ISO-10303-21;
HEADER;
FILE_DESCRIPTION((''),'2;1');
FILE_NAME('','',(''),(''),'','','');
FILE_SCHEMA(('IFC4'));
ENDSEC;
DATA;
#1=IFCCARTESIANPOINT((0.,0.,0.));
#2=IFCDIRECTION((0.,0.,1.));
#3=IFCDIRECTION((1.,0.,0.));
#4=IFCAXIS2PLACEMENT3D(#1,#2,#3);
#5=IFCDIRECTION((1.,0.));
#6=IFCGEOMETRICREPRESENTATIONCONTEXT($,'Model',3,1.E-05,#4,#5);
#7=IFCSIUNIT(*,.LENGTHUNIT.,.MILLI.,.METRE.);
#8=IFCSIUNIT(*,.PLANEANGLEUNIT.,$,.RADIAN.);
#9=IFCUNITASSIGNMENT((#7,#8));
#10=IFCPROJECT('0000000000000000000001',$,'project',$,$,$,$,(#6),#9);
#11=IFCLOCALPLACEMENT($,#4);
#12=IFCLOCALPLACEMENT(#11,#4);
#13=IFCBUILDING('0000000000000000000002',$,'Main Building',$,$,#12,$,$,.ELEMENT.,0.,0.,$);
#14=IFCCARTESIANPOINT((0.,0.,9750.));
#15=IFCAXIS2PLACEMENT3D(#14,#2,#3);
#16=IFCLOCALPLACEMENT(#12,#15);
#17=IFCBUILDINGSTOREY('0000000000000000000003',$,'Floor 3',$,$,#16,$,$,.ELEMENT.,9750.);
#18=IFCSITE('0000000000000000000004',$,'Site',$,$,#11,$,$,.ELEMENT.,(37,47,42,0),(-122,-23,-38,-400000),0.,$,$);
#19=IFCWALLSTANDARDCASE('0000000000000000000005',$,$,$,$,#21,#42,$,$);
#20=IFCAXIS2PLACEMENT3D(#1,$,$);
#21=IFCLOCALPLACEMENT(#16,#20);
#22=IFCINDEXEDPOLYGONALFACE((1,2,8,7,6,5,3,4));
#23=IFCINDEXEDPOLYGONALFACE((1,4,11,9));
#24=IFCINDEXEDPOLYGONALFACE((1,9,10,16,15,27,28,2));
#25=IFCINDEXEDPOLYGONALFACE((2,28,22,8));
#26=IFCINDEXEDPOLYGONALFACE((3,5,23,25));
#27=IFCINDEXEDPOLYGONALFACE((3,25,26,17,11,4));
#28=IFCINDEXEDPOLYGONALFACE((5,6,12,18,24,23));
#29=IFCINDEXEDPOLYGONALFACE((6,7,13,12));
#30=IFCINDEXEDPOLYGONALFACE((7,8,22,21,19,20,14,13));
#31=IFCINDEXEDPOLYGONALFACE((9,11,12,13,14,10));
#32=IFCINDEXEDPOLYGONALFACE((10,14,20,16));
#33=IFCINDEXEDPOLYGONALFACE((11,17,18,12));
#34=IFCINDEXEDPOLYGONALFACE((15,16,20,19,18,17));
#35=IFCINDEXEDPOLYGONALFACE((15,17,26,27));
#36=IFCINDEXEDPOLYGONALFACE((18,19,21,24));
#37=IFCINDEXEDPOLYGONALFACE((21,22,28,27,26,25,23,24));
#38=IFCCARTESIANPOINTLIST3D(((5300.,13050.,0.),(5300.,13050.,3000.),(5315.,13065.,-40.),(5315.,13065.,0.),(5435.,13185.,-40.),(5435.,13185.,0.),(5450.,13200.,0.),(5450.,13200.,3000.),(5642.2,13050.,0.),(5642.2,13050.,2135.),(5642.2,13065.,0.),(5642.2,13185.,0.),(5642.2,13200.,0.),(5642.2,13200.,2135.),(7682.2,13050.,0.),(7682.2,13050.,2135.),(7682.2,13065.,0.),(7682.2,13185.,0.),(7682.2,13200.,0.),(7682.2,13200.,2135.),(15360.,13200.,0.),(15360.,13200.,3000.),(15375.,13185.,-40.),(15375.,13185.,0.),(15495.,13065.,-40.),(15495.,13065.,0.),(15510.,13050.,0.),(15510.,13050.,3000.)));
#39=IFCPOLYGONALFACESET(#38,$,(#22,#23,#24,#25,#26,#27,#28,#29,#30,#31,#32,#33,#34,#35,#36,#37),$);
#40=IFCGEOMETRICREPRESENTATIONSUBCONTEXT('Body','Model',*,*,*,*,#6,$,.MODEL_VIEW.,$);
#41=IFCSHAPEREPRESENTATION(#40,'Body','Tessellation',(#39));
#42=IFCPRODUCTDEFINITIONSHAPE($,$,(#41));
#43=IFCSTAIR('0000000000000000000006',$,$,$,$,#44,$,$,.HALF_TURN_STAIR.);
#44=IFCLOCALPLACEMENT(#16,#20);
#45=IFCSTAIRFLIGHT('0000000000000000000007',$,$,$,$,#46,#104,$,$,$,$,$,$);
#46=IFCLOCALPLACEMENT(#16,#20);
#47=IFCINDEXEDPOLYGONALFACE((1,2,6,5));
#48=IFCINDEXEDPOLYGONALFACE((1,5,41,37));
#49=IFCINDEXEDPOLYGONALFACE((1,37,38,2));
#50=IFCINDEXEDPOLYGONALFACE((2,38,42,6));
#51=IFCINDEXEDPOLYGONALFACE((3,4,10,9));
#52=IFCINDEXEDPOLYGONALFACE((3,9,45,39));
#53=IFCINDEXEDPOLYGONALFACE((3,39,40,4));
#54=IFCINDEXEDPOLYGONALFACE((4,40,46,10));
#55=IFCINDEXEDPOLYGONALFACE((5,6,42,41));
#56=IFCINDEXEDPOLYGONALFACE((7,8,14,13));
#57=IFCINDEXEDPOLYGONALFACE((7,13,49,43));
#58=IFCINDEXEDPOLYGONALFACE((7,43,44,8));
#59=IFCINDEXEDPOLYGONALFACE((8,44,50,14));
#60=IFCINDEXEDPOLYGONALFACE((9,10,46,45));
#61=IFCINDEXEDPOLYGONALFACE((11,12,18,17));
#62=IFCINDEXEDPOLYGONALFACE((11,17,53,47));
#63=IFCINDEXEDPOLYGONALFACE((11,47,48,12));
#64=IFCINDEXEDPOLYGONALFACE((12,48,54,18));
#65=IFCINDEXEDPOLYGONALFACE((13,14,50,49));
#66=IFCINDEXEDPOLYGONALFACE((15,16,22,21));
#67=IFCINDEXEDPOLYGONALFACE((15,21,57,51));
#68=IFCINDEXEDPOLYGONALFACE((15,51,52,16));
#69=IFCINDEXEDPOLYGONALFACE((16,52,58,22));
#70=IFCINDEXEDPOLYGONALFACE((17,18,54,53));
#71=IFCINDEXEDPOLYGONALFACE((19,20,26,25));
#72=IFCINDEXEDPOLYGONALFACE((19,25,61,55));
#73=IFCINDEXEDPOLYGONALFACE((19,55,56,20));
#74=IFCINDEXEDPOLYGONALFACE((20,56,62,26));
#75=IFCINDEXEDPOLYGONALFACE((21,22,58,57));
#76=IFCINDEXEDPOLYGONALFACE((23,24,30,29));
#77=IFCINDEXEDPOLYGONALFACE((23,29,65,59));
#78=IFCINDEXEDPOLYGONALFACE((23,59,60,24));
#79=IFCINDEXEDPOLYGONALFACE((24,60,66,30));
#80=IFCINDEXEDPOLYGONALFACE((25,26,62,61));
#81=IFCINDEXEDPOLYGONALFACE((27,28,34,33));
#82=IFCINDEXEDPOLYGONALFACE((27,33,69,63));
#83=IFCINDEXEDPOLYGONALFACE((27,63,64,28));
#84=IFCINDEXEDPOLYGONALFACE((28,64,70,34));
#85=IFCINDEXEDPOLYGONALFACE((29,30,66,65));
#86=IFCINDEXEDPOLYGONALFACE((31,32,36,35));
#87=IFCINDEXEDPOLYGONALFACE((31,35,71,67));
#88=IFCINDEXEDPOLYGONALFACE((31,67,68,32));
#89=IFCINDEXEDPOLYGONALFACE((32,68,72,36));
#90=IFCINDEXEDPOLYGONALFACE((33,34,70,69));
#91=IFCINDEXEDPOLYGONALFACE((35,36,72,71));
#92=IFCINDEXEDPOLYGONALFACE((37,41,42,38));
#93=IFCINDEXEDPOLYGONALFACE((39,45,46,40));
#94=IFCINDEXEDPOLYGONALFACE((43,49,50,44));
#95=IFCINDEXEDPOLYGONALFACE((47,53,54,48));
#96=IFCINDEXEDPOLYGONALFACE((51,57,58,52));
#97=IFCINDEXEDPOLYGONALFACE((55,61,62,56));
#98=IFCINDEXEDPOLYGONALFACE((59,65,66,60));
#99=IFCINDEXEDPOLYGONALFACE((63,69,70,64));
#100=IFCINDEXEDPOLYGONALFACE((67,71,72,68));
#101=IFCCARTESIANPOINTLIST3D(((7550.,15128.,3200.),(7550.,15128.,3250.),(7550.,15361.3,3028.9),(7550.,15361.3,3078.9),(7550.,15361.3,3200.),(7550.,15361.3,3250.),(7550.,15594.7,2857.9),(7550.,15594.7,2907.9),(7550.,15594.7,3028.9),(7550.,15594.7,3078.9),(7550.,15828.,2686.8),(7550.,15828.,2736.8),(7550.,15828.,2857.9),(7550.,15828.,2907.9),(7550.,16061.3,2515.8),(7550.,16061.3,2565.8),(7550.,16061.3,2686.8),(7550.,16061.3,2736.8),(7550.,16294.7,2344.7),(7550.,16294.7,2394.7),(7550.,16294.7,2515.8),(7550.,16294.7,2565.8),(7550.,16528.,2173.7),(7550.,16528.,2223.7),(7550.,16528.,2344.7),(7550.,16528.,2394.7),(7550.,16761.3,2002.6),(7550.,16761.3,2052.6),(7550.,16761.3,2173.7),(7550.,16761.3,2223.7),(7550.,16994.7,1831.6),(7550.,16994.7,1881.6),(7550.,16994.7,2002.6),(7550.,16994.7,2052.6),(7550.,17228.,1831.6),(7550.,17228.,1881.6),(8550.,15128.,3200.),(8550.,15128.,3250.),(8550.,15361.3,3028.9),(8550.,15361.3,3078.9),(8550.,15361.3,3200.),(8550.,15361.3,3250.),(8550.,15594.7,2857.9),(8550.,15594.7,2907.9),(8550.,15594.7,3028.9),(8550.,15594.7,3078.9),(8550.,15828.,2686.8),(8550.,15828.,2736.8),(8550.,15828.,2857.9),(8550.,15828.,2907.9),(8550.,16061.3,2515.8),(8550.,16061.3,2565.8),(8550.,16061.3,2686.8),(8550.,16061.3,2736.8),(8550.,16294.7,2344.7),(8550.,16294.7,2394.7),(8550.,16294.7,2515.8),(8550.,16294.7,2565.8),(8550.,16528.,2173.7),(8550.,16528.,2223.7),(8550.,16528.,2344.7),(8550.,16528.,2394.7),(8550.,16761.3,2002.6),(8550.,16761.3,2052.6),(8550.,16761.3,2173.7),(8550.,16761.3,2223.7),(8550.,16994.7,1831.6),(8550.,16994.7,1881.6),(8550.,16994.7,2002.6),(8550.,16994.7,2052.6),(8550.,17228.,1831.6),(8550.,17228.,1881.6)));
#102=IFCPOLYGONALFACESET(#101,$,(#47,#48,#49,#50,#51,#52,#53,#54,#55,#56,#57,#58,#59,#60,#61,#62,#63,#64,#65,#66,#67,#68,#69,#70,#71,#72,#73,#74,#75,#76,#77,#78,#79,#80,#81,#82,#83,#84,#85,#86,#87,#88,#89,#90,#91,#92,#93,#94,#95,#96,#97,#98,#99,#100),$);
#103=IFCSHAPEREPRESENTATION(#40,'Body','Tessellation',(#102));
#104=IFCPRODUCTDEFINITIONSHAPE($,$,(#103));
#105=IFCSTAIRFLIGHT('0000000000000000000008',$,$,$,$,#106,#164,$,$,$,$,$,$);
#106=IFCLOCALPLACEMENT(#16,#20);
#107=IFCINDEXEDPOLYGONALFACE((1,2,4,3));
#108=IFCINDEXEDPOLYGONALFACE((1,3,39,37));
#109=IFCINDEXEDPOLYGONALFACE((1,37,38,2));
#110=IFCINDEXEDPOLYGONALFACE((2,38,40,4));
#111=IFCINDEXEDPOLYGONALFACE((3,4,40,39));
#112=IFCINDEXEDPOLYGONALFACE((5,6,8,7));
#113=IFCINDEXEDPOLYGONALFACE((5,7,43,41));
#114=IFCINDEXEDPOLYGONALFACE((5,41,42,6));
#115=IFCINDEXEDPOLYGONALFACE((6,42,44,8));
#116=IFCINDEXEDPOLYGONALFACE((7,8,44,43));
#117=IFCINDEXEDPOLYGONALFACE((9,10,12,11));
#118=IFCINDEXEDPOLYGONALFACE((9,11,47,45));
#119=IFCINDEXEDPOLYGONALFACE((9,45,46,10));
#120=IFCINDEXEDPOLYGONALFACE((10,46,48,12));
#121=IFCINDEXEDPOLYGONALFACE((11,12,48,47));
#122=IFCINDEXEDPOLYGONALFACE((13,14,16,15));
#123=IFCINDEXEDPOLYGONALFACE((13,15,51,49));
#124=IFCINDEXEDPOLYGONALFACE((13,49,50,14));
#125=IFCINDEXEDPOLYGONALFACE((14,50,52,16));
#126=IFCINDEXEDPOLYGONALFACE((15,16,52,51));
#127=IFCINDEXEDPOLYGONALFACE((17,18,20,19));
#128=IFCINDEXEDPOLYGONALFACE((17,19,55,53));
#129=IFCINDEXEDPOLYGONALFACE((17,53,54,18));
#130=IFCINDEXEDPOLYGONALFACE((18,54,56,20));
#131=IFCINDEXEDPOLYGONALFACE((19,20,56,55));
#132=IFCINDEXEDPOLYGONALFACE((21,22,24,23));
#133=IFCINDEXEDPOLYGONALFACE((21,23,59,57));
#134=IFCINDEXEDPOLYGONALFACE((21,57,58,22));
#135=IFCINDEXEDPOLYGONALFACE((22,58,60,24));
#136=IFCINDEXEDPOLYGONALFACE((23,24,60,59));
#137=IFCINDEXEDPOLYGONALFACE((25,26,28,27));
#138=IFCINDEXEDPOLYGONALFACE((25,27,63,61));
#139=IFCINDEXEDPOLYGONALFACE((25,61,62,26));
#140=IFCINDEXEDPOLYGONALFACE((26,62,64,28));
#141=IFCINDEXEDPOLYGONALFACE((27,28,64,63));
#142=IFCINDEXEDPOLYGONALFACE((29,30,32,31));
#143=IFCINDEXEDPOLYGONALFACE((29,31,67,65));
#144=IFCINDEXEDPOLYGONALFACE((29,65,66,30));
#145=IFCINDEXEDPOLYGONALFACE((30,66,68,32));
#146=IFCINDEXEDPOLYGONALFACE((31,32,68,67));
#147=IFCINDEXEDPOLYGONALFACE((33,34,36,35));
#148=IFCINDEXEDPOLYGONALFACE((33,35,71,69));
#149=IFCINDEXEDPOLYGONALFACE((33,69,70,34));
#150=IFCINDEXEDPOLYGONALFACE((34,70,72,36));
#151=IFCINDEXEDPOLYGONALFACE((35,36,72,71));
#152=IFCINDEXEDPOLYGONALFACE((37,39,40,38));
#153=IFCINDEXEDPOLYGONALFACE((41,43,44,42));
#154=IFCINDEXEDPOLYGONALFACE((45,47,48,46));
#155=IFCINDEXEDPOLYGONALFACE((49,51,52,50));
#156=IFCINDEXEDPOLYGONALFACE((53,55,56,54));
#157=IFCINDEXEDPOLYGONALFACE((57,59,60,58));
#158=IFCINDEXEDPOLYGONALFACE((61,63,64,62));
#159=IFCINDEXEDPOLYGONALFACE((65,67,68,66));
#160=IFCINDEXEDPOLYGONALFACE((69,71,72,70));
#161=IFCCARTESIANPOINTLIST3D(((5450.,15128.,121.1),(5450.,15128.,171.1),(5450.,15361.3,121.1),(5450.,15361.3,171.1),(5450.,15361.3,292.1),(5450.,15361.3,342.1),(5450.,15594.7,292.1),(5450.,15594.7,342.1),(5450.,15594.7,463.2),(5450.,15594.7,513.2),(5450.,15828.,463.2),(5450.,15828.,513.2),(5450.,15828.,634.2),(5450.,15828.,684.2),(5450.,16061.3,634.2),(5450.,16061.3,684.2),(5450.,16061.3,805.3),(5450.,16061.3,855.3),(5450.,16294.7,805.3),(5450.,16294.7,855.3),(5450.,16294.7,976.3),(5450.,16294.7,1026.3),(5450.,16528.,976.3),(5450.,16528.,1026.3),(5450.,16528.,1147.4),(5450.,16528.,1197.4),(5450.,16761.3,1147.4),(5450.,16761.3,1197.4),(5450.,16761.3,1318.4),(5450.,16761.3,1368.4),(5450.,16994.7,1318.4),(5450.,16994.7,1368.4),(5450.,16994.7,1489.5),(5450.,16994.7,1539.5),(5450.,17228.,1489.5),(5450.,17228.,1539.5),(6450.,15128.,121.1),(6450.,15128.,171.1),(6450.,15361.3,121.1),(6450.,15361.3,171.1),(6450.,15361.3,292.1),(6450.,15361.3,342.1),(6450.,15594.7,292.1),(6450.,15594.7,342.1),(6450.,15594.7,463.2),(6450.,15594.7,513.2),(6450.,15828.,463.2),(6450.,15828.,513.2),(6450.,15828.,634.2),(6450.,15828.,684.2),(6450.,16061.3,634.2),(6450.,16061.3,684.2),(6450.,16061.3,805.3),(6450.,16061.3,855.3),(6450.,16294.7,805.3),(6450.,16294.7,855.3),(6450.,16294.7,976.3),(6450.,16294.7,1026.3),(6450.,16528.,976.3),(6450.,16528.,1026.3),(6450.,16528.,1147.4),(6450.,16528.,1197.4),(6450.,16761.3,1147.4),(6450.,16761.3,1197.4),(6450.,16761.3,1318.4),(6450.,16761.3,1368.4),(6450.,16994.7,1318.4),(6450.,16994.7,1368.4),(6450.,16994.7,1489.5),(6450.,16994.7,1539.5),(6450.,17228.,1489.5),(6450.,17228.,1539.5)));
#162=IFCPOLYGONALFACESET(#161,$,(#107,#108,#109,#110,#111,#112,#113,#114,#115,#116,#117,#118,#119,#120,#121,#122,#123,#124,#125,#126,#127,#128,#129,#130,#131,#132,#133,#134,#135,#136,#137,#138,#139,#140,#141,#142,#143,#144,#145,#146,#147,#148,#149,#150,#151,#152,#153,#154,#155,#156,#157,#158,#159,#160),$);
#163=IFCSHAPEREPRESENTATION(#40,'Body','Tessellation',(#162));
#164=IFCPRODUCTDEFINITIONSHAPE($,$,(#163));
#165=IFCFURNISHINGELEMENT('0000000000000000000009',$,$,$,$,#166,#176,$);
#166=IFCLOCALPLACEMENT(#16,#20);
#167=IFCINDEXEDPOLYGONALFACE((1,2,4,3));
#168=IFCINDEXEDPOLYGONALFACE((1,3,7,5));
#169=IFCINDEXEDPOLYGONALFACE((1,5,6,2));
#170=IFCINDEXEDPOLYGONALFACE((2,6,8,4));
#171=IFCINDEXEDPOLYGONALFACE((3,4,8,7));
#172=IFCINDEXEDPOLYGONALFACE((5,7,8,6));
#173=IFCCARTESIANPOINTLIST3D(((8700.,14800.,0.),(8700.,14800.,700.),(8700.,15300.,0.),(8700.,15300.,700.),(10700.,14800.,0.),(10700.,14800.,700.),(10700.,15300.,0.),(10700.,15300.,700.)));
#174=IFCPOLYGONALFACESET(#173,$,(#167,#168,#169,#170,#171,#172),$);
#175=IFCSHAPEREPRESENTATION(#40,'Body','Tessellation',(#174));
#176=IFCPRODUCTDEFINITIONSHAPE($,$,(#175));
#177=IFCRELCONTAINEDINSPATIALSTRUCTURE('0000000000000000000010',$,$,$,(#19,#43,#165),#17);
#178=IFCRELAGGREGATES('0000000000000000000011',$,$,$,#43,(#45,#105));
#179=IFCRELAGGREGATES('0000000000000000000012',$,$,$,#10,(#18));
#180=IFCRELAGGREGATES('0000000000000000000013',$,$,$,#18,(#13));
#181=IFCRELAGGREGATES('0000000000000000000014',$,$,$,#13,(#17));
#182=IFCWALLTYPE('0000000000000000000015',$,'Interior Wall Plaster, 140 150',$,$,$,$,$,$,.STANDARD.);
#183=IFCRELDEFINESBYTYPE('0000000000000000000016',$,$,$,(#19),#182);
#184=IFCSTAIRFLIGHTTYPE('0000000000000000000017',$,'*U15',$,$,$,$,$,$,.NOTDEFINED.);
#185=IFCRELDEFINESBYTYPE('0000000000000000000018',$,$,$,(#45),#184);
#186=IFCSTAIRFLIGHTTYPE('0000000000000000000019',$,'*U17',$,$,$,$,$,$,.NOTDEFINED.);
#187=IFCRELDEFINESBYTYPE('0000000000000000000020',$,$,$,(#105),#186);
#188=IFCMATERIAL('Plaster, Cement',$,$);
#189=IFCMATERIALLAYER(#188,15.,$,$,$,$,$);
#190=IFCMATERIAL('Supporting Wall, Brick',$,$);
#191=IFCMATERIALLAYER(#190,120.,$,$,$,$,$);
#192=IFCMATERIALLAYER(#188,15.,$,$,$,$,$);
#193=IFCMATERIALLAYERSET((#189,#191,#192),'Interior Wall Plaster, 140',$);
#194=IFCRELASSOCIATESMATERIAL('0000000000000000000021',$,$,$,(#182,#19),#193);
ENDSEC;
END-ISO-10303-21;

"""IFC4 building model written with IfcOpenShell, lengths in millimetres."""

from ifc_helpers import new_model, si_unit, direction, frame, frame_2d, origin_with_axes, origin_2d_with_axis, place, context, subcontext, project, spatial, polyline, rectangle, outline, extrude, clip, bounded_halfspace, source, transform, mapped, material, layer, layer_set, layer_usage, type_object, type_shapes, element, aggregate, save


model = new_model("IFC4")

# Units and contexts
model_context = context("Model", 3, precision=1e-05, world=origin_with_axes(), true_north=direction((1.0, 0.0)))
body_context = subcontext(model_context, "Body", "Model", "MODEL_VIEW")
ifc_project = project(units=[si_unit("LENGTHUNIT", "METRE", prefix="MILLI"), si_unit("PLANEANGLEUNIT", "RADIAN")], contexts=[model_context])

# Site, building, storey
site_placement = place(None, origin_with_axes())
site = spatial("IfcSite", under=ifc_project, at=site_placement, Name="Site", CompositionType="ELEMENT", RefLatitude=(37, 47, 42, 0), RefLongitude=(-122, -23, -38, -400000), RefElevation=0.0)
building_placement = place(site_placement, origin_with_axes())
building = spatial("IfcBuilding", under=site, at=building_placement, Name="Main Building", CompositionType="ELEMENT", ElevationOfRefHeight=0.0, ElevationOfTerrain=0.0)
storey_placement = place(building_placement, frame((0.0, 0.0, 9750.0), z_axis=(0.0, 0.0, 1.0), x_axis=(1.0, 0.0, 0.0)))
storey = spatial("IfcBuildingStorey", under=building, at=storey_placement, Name="Floor 3", CompositionType="ELEMENT", Elevation=9750.0)

# Shared definitions
ifc_material_1 = material(Name="Plaster, Cement")
ifc_layer_1 = layer(ifc_material_1, 15.0)
ifc_material_2 = material(Name="Supporting Wall, Brick")
ifc_layer_2 = layer(ifc_material_2, 120.0)
ifc_layer_3 = layer(ifc_material_1, 15.0)
ifc_layer_set = layer_set([ifc_layer_1, ifc_layer_2, ifc_layer_3], Name="Interior Wall Plaster, 140")
wall_type = type_object("IfcWallType", Name="Interior Wall Plaster, 140 150", PredefinedType="STANDARD", material=ifc_layer_set)

# Wall, opening
ifc_layer_usage_1 = layer_usage(ifc_layer_set, "AXIS2", "POSITIVE", 0.0)
wall_1_placement = place(storey_placement, frame((5300.0, 13050.0, -40.0), z_axis=(0.0, 0.0, 1.0), x_axis=(1.0, 0.0, 0.0)))
wall_1 = element("IfcWallStandardCase", 1, at=wall_1_placement, inside=storey, type_object=wall_type, material=ifc_layer_usage_1, context=body_context, shape_type="Clipping", body=[
    clip(clip(extrude(outline(polyline([(-4955.0, 75.0), (4955.0, 75.0), (5105.0, -75.0), (-5105.0, -75.0), (-4955.0, 75.0)])), frame((5105.0, 75.0, 0.0), z_axis=(0.0, 0.0, 1.0), x_axis=(1.0, 0.0, 0.0)), (0.0, 0.0, 1.0), 3040.0), bounded_halfspace(frame((-5300.0, -13050.0, 40.0), z_axis=(0.0, 0.0, -1.0), x_axis=(-1.0, 0.0, 0.0)), False, frame((5105.0, 75.0, 0.0), z_axis=(0.0, 0.0, 1.0), x_axis=(1.0, 0.0, 0.0)), polyline([(-4955.0, 75.0), (4955.0, 75.0), (4970.0, 60.0), (-4970.0, 60.0), (-4955.0, 75.0)]))), bounded_halfspace(frame((-5300.0, -13050.0, 40.0), z_axis=(0.0, 0.0, -1.0), x_axis=(-1.0, 0.0, 0.0)), False, frame((5105.0, 75.0, 0.0), z_axis=(0.0, 0.0, 1.0), x_axis=(1.0, 0.0, 0.0)), polyline([(-5090.0, -60.0), (5090.0, -60.0), (5105.0, -75.0), (-5105.0, -75.0), (-5090.0, -60.0)]))),
])
opening_1_placement = place(wall_1_placement, frame((2382.2, 150.0, 40.0), z_axis=(0.0, 0.0, 1.0), x_axis=(-1.0, 0.0, 0.0)))
element("IfcOpeningElement", 2, at=opening_1_placement, cuts=wall_1, ObjectType="Opening", context=body_context, shape_type="SweptSolid", body=[
    extrude(outline(polyline([(-1020.0, -1067.5), (-1020.0, 1067.5), (1020.0, 1067.5), (1020.0, -1067.5), (-1020.0, -1067.5)])), frame((1020.0, 0.0, 1067.5), z_axis=(0.0, 1.0, 0.0), x_axis=(1.0, 0.0, 0.0)), (0.0, 0.0, 1.0), 1000.0),
])

# Stair, stair flights
stair_placement = place(storey_placement, frame((8550.0, 15128.0, 3250.0), z_axis=(0.0, 0.0, 1.0), x_axis=(0.0, 1.0, 0.0)))
stair = element("IfcStair", 3, at=stair_placement, inside=storey, PredefinedType="HALF_TURN_STAIR")
stair_flight_type_1 = type_object("IfcStairFlightType", Name="*U15", PredefinedType="NOTDEFINED")
shared_shape_1 = source(origin_with_axes(), body_context, "Body", "SweptSolid", [
    extrude(rectangle(XDim=1000.0, YDim=233.3, at=frame_2d((0.0, 0.0), x_axis=(0.0, 1.0))), frame((116.7, 500.0, -50.0), z_axis=(0.0, 0.0, 1.0), x_axis=(1.0, 0.0, 0.0)), (0.0, 0.0, 1.0), 50.0),
])
shared_shape_2 = source(origin_with_axes(), body_context, "Body", "MappedRepresentation", [
    mapped(shared_shape_1, transform((0.0, 0.0, 0.0), x_axis=(1.0, 0.0, 0.0), y_axis=(0.0, 1.0, 0.0), z_axis=(0.0, 0.0, 1.0), scale=1.0)),
    mapped(shared_shape_1, transform((233.3, 0.0, -171.1), x_axis=(1.0, 0.0, 0.0), y_axis=(0.0, 1.0, 0.0), z_axis=(0.0, 0.0, 1.0), scale=1.0)),
    mapped(shared_shape_1, transform((466.7, 0.0, -342.1), x_axis=(1.0, 0.0, 0.0), y_axis=(0.0, 1.0, 0.0), z_axis=(0.0, 0.0, 1.0), scale=1.0)),
    mapped(shared_shape_1, transform((700.0, 0.0, -513.2), x_axis=(1.0, 0.0, 0.0), y_axis=(0.0, 1.0, 0.0), z_axis=(0.0, 0.0, 1.0), scale=1.0)),
    mapped(shared_shape_1, transform((933.3, 0.0, -684.2), x_axis=(1.0, 0.0, 0.0), y_axis=(0.0, 1.0, 0.0), z_axis=(0.0, 0.0, 1.0), scale=1.0)),
    mapped(shared_shape_1, transform((1166.7, 0.0, -855.3), x_axis=(1.0, 0.0, 0.0), y_axis=(0.0, 1.0, 0.0), z_axis=(0.0, 0.0, 1.0), scale=1.0)),
    mapped(shared_shape_1, transform((1400.0, 0.0, -1026.3), x_axis=(1.0, 0.0, 0.0), y_axis=(0.0, 1.0, 0.0), z_axis=(0.0, 0.0, 1.0), scale=1.0)),
    mapped(shared_shape_1, transform((1633.3, 0.0, -1197.4), x_axis=(1.0, 0.0, 0.0), y_axis=(0.0, 1.0, 0.0), z_axis=(0.0, 0.0, 1.0), scale=1.0)),
    mapped(shared_shape_1, transform((1866.7, 0.0, -1368.4), x_axis=(1.0, 0.0, 0.0), y_axis=(0.0, 1.0, 0.0), z_axis=(0.0, 0.0, 1.0), scale=1.0)),
])
type_shapes(stair_flight_type_1, [shared_shape_2])
stair_flight_1_placement = place(stair_placement, origin_with_axes())
stair_flight_1 = element("IfcStairFlight", 4, at=stair_flight_1_placement, type_object=stair_flight_type_1, context=body_context, shape_type="MappedRepresentation", body=[
    mapped(shared_shape_2, transform((0.0, 0.0, 0.0), x_axis=(1.0, 0.0, 0.0), y_axis=(0.0, 1.0, 0.0), z_axis=(0.0, 0.0, 1.0), scale=1.0)),
])
stair_flight_type_2 = type_object("IfcStairFlightType", Name="*U17", PredefinedType="NOTDEFINED")
shared_shape_3 = source(origin_with_axes(), body_context, "Body", "SweptSolid", [
    extrude(rectangle(XDim=1000.0, YDim=233.3, at=frame_2d((0.0, 0.0), x_axis=(0.0, 1.0))), frame((1983.3, 2600.0, -1760.5), z_axis=(0.0, 0.0, 1.0), x_axis=(1.0, 0.0, 0.0)), (0.0, 0.0, 1.0), 50.0),
])
shared_shape_4 = source(origin_with_axes(), body_context, "Body", "MappedRepresentation", [
    mapped(shared_shape_3, transform((0.0, 0.0, 0.0), x_axis=(1.0, 0.0, 0.0), y_axis=(0.0, 1.0, 0.0), z_axis=(0.0, 0.0, 1.0), scale=1.0)),
    mapped(shared_shape_3, transform((-233.3, 0.0, -171.1), x_axis=(1.0, 0.0, 0.0), y_axis=(0.0, 1.0, 0.0), z_axis=(0.0, 0.0, 1.0), scale=1.0)),
    mapped(shared_shape_3, transform((-466.7, 0.0, -342.1), x_axis=(1.0, 0.0, 0.0), y_axis=(0.0, 1.0, 0.0), z_axis=(0.0, 0.0, 1.0), scale=1.0)),
    mapped(shared_shape_3, transform((-700.0, 0.0, -513.2), x_axis=(1.0, 0.0, 0.0), y_axis=(0.0, 1.0, 0.0), z_axis=(0.0, 0.0, 1.0), scale=1.0)),
    mapped(shared_shape_3, transform((-933.3, 0.0, -684.2), x_axis=(1.0, 0.0, 0.0), y_axis=(0.0, 1.0, 0.0), z_axis=(0.0, 0.0, 1.0), scale=1.0)),
    mapped(shared_shape_3, transform((-1166.7, 0.0, -855.3), x_axis=(1.0, 0.0, 0.0), y_axis=(0.0, 1.0, 0.0), z_axis=(0.0, 0.0, 1.0), scale=1.0)),
    mapped(shared_shape_3, transform((-1400.0, 0.0, -1026.3), x_axis=(1.0, 0.0, 0.0), y_axis=(0.0, 1.0, 0.0), z_axis=(0.0, 0.0, 1.0), scale=1.0)),
    mapped(shared_shape_3, transform((-1633.3, 0.0, -1197.4), x_axis=(1.0, 0.0, 0.0), y_axis=(0.0, 1.0, 0.0), z_axis=(0.0, 0.0, 1.0), scale=1.0)),
    mapped(shared_shape_3, transform((-1866.7, 0.0, -1368.4), x_axis=(1.0, 0.0, 0.0), y_axis=(0.0, 1.0, 0.0), z_axis=(0.0, 0.0, 1.0), scale=1.0)),
])
type_shapes(stair_flight_type_2, [shared_shape_4])
stair_flight_2_placement = place(stair_placement, origin_with_axes())
stair_flight_2 = element("IfcStairFlight", 5, at=stair_flight_2_placement, type_object=stair_flight_type_2, context=body_context, shape_type="MappedRepresentation", body=[
    mapped(shared_shape_4, transform((0.0, 0.0, 0.0), x_axis=(1.0, 0.0, 0.0), y_axis=(0.0, 1.0, 0.0), z_axis=(0.0, 0.0, 1.0), scale=1.0)),
])

# Furnishing element
furnishing_placement = place(storey_placement, frame((8700.0, 14800.0, 0.0), z_axis=(0.0, 0.0, 1.0), x_axis=(1.0, 0.0, 0.0)))
element("IfcFurnishingElement", 6, at=furnishing_placement, inside=storey, context=body_context, shape_type="SweptSolid", body=[
    extrude(rectangle(XDim=2000.0, YDim=500.0, at=origin_2d_with_axis()), frame((1000.0, 250.0, 0.0), z_axis=(0.0, 0.0, 1.0), x_axis=(1.0, 0.0, 0.0)), (0.0, 0.0, 1.0), 700.0),
])

aggregate(stair, [stair_flight_1, stair_flight_2])

save(model, "model.ifc")
